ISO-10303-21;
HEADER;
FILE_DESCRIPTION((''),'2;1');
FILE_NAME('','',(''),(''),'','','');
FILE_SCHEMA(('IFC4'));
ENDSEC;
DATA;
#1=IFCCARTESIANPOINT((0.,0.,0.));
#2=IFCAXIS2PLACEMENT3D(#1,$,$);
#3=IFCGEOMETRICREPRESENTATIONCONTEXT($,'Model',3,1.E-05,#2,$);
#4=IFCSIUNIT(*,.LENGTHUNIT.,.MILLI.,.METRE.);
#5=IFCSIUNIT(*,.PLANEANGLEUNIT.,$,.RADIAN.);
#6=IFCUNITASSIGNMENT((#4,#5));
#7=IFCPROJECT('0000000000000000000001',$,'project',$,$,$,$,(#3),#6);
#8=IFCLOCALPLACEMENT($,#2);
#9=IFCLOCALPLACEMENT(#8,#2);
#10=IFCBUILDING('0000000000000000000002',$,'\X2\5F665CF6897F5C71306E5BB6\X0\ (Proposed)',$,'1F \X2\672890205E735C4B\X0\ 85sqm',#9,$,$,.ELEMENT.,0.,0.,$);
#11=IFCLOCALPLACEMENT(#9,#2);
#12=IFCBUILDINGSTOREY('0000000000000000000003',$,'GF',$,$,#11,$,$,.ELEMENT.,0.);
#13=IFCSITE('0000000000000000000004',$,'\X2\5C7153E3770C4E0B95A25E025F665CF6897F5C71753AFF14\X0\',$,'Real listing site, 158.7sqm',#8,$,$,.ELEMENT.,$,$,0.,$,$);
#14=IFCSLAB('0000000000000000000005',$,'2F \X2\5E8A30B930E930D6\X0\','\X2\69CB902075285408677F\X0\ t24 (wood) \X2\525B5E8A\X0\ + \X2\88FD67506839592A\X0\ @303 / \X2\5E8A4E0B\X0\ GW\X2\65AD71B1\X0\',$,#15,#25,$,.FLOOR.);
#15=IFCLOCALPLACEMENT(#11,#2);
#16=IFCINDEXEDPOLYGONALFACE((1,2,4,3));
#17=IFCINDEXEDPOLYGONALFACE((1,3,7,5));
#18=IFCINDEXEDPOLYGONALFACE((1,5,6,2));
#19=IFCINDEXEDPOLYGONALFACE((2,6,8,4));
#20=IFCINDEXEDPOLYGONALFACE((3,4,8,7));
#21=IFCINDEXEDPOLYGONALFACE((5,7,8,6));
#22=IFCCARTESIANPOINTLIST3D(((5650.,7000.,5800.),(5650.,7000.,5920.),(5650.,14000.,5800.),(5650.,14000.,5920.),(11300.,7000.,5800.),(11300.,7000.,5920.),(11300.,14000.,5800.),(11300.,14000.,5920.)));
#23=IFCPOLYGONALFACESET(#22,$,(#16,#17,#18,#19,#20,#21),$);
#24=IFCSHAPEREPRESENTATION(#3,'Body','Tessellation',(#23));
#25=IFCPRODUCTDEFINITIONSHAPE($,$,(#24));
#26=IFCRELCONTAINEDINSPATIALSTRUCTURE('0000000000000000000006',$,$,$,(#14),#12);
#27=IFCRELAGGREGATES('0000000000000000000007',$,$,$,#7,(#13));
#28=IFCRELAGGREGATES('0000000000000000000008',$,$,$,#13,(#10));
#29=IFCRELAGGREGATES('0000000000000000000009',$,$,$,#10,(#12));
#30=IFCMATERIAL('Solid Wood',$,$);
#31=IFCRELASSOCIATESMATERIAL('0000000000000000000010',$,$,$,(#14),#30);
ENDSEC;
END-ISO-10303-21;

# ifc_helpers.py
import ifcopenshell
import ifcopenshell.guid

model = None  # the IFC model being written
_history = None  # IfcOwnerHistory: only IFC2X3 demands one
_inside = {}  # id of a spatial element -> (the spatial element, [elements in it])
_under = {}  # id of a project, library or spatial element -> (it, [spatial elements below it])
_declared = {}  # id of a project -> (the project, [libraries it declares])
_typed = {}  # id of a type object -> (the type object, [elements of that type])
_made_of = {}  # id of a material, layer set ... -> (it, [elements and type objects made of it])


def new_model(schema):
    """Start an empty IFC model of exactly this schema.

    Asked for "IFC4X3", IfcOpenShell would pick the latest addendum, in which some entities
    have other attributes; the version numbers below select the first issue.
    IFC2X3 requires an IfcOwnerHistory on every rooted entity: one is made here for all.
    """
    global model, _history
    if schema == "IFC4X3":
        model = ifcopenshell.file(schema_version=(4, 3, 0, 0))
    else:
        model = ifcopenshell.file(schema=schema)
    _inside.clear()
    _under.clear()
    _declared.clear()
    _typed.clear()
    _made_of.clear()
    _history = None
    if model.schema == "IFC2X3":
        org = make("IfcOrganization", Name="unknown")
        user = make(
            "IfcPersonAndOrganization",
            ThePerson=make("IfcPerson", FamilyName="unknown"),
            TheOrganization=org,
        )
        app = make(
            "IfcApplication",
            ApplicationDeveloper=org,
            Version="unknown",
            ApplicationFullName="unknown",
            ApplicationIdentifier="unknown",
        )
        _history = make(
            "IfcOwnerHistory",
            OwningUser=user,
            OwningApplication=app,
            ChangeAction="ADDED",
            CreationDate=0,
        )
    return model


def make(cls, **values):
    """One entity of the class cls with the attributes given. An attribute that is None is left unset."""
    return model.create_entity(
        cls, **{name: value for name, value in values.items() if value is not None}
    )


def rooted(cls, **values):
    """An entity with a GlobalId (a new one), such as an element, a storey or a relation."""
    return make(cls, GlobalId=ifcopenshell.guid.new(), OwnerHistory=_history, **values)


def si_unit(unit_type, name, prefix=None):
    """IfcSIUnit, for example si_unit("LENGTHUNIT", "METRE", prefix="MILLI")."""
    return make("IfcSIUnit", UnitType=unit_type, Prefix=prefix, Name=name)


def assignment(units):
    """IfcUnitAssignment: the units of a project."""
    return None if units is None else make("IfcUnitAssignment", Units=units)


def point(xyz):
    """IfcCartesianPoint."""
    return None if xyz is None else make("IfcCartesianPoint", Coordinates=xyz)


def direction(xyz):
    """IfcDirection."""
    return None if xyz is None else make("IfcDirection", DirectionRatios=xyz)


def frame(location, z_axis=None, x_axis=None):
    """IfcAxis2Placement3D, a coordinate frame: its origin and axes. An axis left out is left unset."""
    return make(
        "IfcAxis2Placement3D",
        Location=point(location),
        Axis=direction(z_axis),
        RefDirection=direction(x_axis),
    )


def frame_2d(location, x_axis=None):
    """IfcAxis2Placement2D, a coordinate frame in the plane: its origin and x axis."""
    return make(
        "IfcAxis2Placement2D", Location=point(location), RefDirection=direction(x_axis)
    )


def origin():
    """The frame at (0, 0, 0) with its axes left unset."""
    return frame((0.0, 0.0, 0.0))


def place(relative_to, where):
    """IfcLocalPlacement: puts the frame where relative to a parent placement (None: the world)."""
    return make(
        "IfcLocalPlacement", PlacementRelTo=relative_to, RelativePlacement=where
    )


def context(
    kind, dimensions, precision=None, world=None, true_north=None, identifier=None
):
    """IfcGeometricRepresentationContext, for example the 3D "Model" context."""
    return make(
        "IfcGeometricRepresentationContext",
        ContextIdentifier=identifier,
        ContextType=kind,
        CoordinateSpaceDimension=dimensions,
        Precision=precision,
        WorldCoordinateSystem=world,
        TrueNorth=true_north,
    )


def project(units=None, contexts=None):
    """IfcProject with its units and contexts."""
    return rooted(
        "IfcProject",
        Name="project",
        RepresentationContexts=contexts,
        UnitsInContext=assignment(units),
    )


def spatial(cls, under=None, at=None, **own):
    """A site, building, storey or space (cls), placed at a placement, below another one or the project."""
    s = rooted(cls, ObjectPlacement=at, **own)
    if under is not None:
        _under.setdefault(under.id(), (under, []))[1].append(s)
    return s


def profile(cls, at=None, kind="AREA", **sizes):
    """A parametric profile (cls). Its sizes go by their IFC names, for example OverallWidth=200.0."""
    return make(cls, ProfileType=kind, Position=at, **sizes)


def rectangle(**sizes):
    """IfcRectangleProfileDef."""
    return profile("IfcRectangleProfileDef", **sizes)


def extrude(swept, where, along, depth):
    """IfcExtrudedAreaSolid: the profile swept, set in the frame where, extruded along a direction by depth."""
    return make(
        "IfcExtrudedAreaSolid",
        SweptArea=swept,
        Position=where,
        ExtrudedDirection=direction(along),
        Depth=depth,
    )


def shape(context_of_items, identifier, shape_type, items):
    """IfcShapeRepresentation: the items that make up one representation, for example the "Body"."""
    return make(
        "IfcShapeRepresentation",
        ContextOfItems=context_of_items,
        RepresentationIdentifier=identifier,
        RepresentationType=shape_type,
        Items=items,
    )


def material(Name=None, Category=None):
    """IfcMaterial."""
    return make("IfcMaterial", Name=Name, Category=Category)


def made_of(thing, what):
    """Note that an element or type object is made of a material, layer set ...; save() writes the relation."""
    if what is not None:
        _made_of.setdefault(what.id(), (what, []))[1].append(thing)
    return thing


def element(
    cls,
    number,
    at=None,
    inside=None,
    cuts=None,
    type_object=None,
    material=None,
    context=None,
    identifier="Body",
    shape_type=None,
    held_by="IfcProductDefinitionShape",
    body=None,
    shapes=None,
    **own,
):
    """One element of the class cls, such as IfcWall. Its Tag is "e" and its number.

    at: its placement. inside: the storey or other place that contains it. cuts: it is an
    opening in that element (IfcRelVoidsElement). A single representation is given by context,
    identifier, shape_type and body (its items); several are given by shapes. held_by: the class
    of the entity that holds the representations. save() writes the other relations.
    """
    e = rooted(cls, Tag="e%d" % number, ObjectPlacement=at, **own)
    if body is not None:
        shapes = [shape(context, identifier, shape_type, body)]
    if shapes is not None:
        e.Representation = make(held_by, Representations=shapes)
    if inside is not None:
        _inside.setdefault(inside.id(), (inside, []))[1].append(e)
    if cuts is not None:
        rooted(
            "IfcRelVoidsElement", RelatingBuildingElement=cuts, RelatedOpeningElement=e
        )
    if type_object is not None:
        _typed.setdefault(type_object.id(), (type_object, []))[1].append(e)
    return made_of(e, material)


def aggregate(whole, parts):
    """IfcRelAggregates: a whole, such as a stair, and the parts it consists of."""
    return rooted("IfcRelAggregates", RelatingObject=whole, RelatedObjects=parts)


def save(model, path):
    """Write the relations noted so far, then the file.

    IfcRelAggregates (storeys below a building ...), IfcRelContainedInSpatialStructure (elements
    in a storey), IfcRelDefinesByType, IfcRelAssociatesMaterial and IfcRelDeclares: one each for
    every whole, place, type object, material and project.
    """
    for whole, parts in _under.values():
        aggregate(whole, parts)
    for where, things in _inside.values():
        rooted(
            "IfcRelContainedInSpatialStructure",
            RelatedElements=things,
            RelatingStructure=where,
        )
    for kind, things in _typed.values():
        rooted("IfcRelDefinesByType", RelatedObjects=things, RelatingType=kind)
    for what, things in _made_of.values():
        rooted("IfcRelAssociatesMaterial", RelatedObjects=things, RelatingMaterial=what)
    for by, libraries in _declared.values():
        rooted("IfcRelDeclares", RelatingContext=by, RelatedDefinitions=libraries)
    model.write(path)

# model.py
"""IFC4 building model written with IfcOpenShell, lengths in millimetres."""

from ifc_helpers import new_model, si_unit, frame, frame_2d, origin, place, context, project, spatial, rectangle, extrude, material, element, save


model = new_model("IFC4")

# Units and contexts
model_context = context("Model", 3, precision=1e-05, world=origin())
ifc_project = project(units=[si_unit("LENGTHUNIT", "METRE", prefix="MILLI"), si_unit("PLANEANGLEUNIT", "RADIAN")], contexts=[model_context])

# Site, building, storey
site_placement = place(None, origin())
site = spatial("IfcSite", under=ifc_project, at=site_placement, Name="山口県下関市彦島西山町４", ObjectType="Real listing site, 158.7sqm", CompositionType="ELEMENT", RefElevation=0.0)
building_placement = place(site_placement, origin())
building = spatial("IfcBuilding", under=site, at=building_placement, Name="彦島西山の家 (Proposed)", ObjectType="1F 木造平屋 85sqm", CompositionType="ELEMENT", ElevationOfRefHeight=0.0, ElevationOfTerrain=0.0)
storey_placement = place(building_placement, origin())
storey = spatial("IfcBuildingStorey", under=building, at=storey_placement, Name="GF", CompositionType="ELEMENT", Elevation=0.0)

# Slab
ifc_material_1 = material(Name="Solid Wood")
slab_placement = place(storey_placement, frame((2825.0, 3500.0, 2900.0)))
element("IfcSlab", 1, at=slab_placement, inside=storey, material=ifc_material_1, Name="2F 床スラブ", Description="構造用合板 t24 (wood) 剛床 + 製材根太 @303 / 床下 GW断熱", PredefinedType="FLOOR", context=model_context, shape_type="SweptSolid", body=[
    extrude(rectangle(XDim=5650.0, YDim=7000.0, at=frame_2d((2825.0, 3500.0))), frame((2825.0, 3500.0, 2900.0)), (0.0, 0.0, 1.0), 120.0),
])

save(model, "model.ifc")
